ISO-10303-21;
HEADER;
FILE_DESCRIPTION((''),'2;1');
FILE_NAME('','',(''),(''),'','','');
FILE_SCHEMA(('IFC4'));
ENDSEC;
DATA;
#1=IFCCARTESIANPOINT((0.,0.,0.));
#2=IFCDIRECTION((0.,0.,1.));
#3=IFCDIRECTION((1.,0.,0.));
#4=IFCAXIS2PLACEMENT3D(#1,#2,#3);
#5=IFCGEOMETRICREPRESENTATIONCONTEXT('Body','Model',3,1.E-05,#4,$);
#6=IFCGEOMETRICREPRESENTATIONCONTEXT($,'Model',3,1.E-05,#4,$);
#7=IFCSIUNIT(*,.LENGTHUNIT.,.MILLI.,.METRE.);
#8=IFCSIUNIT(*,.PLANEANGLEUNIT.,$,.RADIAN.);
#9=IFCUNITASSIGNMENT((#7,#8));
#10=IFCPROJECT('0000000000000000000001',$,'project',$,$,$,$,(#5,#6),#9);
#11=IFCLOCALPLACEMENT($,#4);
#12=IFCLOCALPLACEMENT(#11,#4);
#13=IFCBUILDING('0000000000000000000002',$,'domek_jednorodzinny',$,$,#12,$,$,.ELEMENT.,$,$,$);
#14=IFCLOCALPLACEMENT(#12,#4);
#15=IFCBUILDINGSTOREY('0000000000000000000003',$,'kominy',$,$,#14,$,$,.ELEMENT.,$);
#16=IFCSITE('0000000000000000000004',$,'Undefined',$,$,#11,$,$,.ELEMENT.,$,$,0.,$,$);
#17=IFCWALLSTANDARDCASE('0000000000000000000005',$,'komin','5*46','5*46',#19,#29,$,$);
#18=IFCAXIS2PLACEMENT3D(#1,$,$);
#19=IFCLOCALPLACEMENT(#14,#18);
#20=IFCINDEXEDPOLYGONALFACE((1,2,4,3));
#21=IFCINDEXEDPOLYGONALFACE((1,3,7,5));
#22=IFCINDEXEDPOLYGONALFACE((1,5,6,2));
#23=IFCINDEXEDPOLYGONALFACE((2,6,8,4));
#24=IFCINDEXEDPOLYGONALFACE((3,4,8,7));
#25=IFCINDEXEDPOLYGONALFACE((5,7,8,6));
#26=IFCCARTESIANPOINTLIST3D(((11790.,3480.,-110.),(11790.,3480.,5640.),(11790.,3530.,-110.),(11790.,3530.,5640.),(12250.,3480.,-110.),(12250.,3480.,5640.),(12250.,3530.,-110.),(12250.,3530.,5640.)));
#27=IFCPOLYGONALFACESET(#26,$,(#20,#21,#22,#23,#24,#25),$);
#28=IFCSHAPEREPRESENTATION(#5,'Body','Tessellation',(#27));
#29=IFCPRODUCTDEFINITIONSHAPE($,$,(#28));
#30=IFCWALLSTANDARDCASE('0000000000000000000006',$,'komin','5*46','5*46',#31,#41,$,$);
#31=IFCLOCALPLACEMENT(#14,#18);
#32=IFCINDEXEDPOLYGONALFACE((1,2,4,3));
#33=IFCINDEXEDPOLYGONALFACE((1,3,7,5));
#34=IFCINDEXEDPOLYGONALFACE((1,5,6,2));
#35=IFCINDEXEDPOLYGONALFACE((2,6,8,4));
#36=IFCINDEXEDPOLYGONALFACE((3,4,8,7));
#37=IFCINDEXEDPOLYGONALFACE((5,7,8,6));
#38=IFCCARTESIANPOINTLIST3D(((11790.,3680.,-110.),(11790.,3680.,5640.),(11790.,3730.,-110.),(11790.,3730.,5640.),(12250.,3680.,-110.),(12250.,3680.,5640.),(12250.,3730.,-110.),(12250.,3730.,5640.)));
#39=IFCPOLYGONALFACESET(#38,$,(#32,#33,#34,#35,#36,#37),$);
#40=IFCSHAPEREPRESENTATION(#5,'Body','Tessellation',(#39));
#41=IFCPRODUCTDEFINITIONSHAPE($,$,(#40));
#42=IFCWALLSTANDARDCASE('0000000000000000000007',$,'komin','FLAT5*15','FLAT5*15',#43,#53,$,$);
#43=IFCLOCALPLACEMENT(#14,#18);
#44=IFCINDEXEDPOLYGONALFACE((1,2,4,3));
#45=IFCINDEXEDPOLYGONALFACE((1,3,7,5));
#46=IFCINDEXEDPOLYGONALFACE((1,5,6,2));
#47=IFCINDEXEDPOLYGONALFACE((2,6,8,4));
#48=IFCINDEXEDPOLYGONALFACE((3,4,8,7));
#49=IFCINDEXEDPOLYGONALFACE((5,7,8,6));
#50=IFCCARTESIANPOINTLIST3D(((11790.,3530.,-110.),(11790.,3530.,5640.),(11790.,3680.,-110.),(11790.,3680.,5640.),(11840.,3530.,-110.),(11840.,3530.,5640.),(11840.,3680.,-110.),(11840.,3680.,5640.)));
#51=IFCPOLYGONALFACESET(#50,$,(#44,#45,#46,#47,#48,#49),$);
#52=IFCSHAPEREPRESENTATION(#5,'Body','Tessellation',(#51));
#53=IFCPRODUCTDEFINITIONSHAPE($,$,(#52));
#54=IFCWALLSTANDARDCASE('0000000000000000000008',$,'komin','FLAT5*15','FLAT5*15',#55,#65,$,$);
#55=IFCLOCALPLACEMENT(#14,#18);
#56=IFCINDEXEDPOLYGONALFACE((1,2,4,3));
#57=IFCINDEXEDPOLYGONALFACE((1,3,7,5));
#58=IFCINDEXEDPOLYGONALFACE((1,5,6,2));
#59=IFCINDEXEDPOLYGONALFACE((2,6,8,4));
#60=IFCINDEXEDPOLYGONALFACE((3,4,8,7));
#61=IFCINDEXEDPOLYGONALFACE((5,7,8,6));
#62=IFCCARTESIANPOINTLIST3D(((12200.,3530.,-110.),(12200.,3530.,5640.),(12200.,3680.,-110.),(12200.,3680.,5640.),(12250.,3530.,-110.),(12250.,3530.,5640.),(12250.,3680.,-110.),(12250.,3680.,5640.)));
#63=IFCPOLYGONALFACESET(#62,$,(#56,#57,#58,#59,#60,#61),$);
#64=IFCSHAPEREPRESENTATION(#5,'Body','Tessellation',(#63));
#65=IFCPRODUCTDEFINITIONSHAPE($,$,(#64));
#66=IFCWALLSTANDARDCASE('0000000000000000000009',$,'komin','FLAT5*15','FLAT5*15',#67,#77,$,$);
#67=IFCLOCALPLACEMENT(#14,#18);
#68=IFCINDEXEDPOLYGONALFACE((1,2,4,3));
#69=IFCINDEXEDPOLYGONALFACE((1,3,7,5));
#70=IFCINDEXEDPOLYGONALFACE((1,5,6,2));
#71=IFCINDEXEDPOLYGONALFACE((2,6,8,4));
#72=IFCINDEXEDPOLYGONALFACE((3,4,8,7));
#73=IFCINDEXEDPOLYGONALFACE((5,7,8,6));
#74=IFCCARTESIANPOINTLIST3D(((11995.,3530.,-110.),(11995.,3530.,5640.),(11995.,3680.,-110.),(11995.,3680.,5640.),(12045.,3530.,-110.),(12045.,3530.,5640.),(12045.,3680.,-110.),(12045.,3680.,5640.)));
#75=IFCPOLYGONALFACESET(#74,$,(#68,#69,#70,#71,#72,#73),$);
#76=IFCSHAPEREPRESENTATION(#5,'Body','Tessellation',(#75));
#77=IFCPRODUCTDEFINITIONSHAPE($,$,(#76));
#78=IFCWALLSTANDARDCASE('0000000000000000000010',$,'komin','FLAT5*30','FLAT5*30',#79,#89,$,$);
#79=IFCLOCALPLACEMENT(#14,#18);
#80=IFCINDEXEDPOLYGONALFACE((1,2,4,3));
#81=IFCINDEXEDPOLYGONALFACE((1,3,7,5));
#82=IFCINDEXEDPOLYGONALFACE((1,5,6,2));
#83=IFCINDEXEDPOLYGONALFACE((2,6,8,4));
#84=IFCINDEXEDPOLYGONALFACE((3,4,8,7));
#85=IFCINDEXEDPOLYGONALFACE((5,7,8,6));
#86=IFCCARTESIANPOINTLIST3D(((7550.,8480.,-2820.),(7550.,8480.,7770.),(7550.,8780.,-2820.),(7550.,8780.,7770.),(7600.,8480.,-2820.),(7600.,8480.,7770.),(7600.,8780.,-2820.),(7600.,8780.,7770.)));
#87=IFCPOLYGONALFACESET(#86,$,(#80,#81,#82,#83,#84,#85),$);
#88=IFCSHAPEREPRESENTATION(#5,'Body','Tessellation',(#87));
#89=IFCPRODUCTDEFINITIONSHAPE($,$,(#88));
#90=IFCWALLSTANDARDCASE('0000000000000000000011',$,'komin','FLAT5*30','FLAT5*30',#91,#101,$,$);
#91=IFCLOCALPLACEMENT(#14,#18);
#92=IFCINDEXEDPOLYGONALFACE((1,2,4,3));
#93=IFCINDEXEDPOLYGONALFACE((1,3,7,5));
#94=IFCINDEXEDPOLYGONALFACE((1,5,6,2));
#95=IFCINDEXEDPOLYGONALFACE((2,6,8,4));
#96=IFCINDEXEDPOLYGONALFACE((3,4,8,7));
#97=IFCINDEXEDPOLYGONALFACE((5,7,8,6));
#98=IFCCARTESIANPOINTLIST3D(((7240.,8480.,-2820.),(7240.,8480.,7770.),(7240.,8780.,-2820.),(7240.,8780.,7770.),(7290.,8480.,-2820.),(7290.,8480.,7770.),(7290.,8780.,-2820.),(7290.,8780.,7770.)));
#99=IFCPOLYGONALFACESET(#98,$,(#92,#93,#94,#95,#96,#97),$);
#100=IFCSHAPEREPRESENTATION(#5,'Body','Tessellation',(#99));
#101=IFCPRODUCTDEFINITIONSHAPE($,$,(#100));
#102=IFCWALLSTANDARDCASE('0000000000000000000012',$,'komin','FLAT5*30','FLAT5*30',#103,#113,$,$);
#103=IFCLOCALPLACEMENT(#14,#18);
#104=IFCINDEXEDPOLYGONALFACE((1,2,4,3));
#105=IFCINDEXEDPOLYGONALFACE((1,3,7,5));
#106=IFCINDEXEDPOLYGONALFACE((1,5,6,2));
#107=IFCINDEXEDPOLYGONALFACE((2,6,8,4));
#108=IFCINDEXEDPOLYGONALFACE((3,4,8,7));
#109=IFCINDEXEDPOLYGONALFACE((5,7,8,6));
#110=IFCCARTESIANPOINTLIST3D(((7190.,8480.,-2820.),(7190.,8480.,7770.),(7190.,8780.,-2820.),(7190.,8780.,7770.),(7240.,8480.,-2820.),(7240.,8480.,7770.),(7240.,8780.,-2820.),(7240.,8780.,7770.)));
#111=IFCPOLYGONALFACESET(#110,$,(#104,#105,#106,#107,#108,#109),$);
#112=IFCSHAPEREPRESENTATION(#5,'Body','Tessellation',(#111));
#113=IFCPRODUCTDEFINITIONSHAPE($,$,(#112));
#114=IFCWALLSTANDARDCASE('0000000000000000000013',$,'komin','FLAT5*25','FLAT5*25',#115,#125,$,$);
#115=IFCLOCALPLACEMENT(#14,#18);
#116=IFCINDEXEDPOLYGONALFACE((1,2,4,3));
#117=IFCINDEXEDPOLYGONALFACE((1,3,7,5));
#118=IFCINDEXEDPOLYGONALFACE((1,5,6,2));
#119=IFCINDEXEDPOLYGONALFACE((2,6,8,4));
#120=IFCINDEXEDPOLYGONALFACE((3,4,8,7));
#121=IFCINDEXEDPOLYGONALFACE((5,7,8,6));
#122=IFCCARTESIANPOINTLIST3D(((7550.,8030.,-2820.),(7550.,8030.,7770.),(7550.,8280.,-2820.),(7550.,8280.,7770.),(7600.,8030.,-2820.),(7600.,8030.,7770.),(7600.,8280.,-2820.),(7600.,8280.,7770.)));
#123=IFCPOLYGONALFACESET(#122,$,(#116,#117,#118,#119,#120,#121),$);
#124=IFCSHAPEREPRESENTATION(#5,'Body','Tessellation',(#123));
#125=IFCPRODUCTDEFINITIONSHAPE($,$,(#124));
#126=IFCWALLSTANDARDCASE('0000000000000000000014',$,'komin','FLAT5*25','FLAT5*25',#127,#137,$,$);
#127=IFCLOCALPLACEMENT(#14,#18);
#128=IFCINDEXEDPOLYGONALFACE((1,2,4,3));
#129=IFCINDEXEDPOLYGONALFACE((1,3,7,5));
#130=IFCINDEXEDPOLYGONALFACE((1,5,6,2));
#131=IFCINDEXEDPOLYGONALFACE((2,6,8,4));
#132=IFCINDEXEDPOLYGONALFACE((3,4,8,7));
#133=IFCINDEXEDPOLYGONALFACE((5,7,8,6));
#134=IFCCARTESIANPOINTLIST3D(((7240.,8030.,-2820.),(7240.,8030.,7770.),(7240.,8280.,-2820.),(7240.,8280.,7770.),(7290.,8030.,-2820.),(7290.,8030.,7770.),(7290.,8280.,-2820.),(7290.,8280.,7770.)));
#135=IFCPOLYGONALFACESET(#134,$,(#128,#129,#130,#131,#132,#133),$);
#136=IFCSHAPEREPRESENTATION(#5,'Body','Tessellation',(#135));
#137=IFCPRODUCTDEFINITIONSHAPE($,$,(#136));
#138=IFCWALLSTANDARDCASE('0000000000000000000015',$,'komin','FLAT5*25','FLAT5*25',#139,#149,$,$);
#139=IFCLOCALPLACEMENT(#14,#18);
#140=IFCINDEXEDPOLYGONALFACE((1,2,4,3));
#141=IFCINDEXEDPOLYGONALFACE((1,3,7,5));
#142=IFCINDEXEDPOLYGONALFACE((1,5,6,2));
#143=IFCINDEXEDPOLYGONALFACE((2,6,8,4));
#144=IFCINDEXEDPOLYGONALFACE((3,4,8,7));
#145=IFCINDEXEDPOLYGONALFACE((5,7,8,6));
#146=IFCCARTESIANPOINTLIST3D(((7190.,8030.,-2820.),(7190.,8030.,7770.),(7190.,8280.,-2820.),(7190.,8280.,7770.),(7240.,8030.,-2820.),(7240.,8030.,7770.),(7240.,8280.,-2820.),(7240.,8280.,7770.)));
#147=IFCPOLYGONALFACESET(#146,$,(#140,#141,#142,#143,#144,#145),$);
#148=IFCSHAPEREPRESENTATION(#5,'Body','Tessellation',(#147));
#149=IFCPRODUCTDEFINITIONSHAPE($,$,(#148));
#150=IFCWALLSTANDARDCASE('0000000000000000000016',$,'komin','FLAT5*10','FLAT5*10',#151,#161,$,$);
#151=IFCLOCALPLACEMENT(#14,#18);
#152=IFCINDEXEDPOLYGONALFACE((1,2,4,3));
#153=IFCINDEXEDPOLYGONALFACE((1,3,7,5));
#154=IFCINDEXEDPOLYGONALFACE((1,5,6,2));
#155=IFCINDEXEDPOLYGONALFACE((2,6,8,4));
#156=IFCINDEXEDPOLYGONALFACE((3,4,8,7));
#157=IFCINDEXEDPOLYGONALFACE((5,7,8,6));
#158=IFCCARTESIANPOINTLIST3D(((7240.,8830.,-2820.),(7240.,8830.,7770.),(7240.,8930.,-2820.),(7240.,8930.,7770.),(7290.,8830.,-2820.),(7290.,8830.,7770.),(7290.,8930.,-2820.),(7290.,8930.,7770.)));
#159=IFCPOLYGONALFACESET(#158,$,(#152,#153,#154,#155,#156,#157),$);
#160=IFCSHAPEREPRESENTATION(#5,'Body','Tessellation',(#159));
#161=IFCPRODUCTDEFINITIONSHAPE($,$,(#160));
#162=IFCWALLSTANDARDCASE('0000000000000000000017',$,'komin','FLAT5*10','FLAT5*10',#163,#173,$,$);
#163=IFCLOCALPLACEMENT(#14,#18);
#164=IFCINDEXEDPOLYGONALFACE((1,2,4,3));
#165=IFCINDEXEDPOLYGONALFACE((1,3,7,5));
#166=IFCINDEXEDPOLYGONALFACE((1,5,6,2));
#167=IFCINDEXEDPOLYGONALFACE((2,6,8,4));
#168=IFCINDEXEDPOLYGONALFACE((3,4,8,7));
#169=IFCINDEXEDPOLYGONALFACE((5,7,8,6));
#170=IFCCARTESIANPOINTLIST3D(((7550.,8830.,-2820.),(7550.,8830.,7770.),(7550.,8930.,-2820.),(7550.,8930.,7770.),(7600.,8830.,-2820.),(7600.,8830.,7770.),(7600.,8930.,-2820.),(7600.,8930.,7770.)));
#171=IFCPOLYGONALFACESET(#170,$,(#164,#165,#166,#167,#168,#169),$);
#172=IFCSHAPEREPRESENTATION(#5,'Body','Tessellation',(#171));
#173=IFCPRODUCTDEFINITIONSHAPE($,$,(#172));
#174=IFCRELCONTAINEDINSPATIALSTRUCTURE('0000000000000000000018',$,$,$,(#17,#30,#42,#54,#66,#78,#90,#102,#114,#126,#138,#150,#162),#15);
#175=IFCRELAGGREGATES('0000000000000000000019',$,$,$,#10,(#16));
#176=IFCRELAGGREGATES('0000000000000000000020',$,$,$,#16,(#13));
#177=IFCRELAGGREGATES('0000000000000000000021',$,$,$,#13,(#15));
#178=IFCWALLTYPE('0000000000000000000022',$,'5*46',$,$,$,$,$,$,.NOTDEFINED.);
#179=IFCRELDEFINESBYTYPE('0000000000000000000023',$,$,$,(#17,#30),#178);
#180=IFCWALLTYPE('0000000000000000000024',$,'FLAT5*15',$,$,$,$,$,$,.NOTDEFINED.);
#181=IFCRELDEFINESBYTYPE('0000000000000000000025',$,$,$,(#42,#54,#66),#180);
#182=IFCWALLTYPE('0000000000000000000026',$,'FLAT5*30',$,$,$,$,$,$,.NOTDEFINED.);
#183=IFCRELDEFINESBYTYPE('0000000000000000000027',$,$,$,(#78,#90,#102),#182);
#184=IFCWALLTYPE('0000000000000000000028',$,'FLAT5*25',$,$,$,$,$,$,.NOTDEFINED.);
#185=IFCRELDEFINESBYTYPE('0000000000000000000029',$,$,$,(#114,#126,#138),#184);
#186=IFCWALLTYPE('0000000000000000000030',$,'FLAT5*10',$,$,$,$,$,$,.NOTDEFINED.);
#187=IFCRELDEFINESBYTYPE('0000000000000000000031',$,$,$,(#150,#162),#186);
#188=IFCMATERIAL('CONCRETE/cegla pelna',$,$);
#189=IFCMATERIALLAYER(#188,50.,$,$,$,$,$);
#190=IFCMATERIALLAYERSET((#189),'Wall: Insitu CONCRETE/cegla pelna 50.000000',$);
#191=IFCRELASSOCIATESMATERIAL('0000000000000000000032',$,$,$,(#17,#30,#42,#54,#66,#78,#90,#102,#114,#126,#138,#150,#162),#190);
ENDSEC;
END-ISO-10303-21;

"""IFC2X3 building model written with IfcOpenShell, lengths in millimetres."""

from ifc_helpers import new_model, si_unit, frame, frame_2d, origin_with_axes, place, context, project, spatial, rectangle, extrude, material, layer, layer_set, layer_usage, type_object, element, save


model = new_model("IFC2X3")

# Units and contexts
model_context_1 = context("Model", 3, precision=1e-05, world=origin_with_axes(), identifier="Body")
model_context_2 = context("Model", 3, precision=1e-05, world=origin_with_axes())
ifc_project = project(units=[si_unit("LENGTHUNIT", "METRE", prefix="MILLI"), si_unit("PLANEANGLEUNIT", "RADIAN")], contexts=[model_context_1, model_context_2])

# Site, building, storey
site_placement = place(None, origin_with_axes())
site = spatial("IfcSite", under=ifc_project, at=site_placement, Name="Undefined", CompositionType="ELEMENT", RefElevation=0.0)
building_placement = place(site_placement, origin_with_axes())
building = spatial("IfcBuilding", under=site, at=building_placement, Name="domek_jednorodzinny", CompositionType="ELEMENT")
storey_placement = place(building_placement, origin_with_axes())
storey = spatial("IfcBuildingStorey", under=building, at=storey_placement, Name="kominy", CompositionType="ELEMENT")

# Walls
ifc_material = material(Name="CONCRETE/cegla pelna")
ifc_layer = layer(ifc_material, 50.0)
ifc_layer_set = layer_set([ifc_layer], Name="Wall: Insitu CONCRETE/cegla pelna 50.000000")
ifc_layer_usage_1 = layer_usage(ifc_layer_set, "AXIS2", "POSITIVE", -25.0)
wall_type_1 = type_object("IfcWallType", Name="5*46", PredefinedType="NOTDEFINED")
wall_1_placement = place(storey_placement, frame((11790.0, 3505.0, -110.0), z_axis=(0.0, 0.0, 1.0), x_axis=(1.0, 0.0, 0.0)))
element("IfcWallStandardCase", 1, at=wall_1_placement, inside=storey, type_object=wall_type_1, material=ifc_layer_usage_1, Name="komin", Description="5*46", ObjectType="5*46", context=model_context_1, shape_type="SweptSolid", body=[
    extrude(rectangle(XDim=460.0, YDim=50.0, at=frame_2d((0.0, 230.0), x_axis=(0.0, -1.0))), frame((0.0, 0.0, 0.0), z_axis=(0.0, 0.0, 1.0), x_axis=(0.0, -1.0, 0.0)), (0.0, 0.0, 1.0), 5750.0),
])
ifc_layer_usage_2 = layer_usage(ifc_layer_set, "AXIS2", "POSITIVE", -25.0)
wall_2_placement = place(storey_placement, frame((11790.0, 3705.0, -110.0), z_axis=(0.0, 0.0, 1.0), x_axis=(1.0, 0.0, 0.0)))
element("IfcWallStandardCase", 2, at=wall_2_placement, inside=storey, type_object=wall_type_1, material=ifc_layer_usage_2, Name="komin", Description="5*46", ObjectType="5*46", context=model_context_1, shape_type="SweptSolid", body=[
    extrude(rectangle(XDim=460.0, YDim=50.0, at=frame_2d((0.0, 230.0), x_axis=(0.0, -1.0))), frame((0.0, 0.0, 0.0), z_axis=(0.0, 0.0, 1.0), x_axis=(0.0, -1.0, 0.0)), (0.0, 0.0, 1.0), 5750.0),
])
ifc_layer_usage_3 = layer_usage(ifc_layer_set, "AXIS2", "POSITIVE", -25.0)
wall_type_2 = type_object("IfcWallType", Name="FLAT5*15", PredefinedType="NOTDEFINED")
wall_3_placement = place(storey_placement, frame((11815.0, 3530.0, -110.0), z_axis=(0.0, 0.0, 1.0), x_axis=(0.0, 1.0, 0.0)))
element("IfcWallStandardCase", 3, at=wall_3_placement, inside=storey, type_object=wall_type_2, material=ifc_layer_usage_3, Name="komin", Description="FLAT5*15", ObjectType="FLAT5*15", context=model_context_1, shape_type="SweptSolid", body=[
    extrude(rectangle(XDim=150.0, YDim=50.0, at=frame_2d((0.0, 75.0), x_axis=(0.0, -1.0))), frame((0.0, 0.0, 0.0), z_axis=(0.0, 0.0, 1.0), x_axis=(0.0, -1.0, 0.0)), (0.0, 0.0, 1.0), 5750.0),
])
ifc_layer_usage_4 = layer_usage(ifc_layer_set, "AXIS2", "POSITIVE", -25.0)
wall_4_placement = place(storey_placement, frame((12225.0, 3530.0, -110.0), z_axis=(0.0, 0.0, 1.0), x_axis=(0.0, 1.0, 0.0)))
element("IfcWallStandardCase", 4, at=wall_4_placement, inside=storey, type_object=wall_type_2, material=ifc_layer_usage_4, Name="komin", Description="FLAT5*15", ObjectType="FLAT5*15", context=model_context_1, shape_type="SweptSolid", body=[
    extrude(rectangle(XDim=150.0, YDim=50.0, at=frame_2d((0.0, 75.0), x_axis=(0.0, -1.0))), frame((0.0, 0.0, 0.0), z_axis=(0.0, 0.0, 1.0), x_axis=(0.0, -1.0, 0.0)), (0.0, 0.0, 1.0), 5750.0),
])
ifc_layer_usage_5 = layer_usage(ifc_layer_set, "AXIS2", "POSITIVE", -25.0)
wall_5_placement = place(storey_placement, frame((12020.0, 3530.0, -110.0), z_axis=(0.0, 0.0, 1.0), x_axis=(0.0, 1.0, 0.0)))
element("IfcWallStandardCase", 5, at=wall_5_placement, inside=storey, type_object=wall_type_2, material=ifc_layer_usage_5, Name="komin", Description="FLAT5*15", ObjectType="FLAT5*15", context=model_context_1, shape_type="SweptSolid", body=[
    extrude(rectangle(XDim=150.0, YDim=50.0, at=frame_2d((0.0, 75.0), x_axis=(0.0, -1.0))), frame((0.0, 0.0, 0.0), z_axis=(0.0, 0.0, 1.0), x_axis=(0.0, -1.0, 0.0)), (0.0, 0.0, 1.0), 5750.0),
])
ifc_layer_usage_6 = layer_usage(ifc_layer_set, "AXIS2", "POSITIVE", -25.0)
wall_type_3 = type_object("IfcWallType", Name="FLAT5*30", PredefinedType="NOTDEFINED")
wall_6_placement = place(storey_placement, frame((7575.0, 8480.0, -2820.0), z_axis=(0.0, 0.0, 1.0), x_axis=(0.0, 1.0, 0.0)))
element("IfcWallStandardCase", 6, at=wall_6_placement, inside=storey, type_object=wall_type_3, material=ifc_layer_usage_6, Name="komin", Description="FLAT5*30", ObjectType="FLAT5*30", context=model_context_1, shape_type="SweptSolid", body=[
    extrude(rectangle(XDim=300.0, YDim=50.0, at=frame_2d((0.0, 150.0), x_axis=(0.0, -1.0))), frame((0.0, 0.0, 0.0), z_axis=(0.0, 0.0, 1.0), x_axis=(0.0, -1.0, 0.0)), (0.0, 0.0, 1.0), 10590.0),
])
ifc_layer_usage_7 = layer_usage(ifc_layer_set, "AXIS2", "POSITIVE", -25.0)
wall_7_placement = place(storey_placement, frame((7265.0, 8480.0, -2820.0), z_axis=(0.0, 0.0, 1.0), x_axis=(0.0, 1.0, 0.0)))
element("IfcWallStandardCase", 7, at=wall_7_placement, inside=storey, type_object=wall_type_3, material=ifc_layer_usage_7, Name="komin", Description="FLAT5*30", ObjectType="FLAT5*30", context=model_context_1, shape_type="SweptSolid", body=[
    extrude(rectangle(XDim=300.0, YDim=50.0, at=frame_2d((0.0, 150.0), x_axis=(0.0, -1.0))), frame((0.0, 0.0, 0.0), z_axis=(0.0, 0.0, 1.0), x_axis=(0.0, -1.0, 0.0)), (0.0, 0.0, 1.0), 10590.0),
])
ifc_layer_usage_8 = layer_usage(ifc_layer_set, "AXIS2", "POSITIVE", -25.0)
wall_8_placement = place(storey_placement, frame((7215.0, 8480.0, -2820.0), z_axis=(0.0, 0.0, 1.0), x_axis=(0.0, 1.0, 0.0)))
element("IfcWallStandardCase", 8, at=wall_8_placement, inside=storey, type_object=wall_type_3, material=ifc_layer_usage_8, Name="komin", Description="FLAT5*30", ObjectType="FLAT5*30", context=model_context_1, shape_type="SweptSolid", body=[
    extrude(rectangle(XDim=300.0, YDim=50.0, at=frame_2d((0.0, 150.0), x_axis=(0.0, -1.0))), frame((0.0, 0.0, 0.0), z_axis=(0.0, 0.0, 1.0), x_axis=(0.0, -1.0, 0.0)), (0.0, 0.0, 1.0), 10590.0),
])
ifc_layer_usage_9 = layer_usage(ifc_layer_set, "AXIS2", "POSITIVE", -25.0)
wall_type_4 = type_object("IfcWallType", Name="FLAT5*25", PredefinedType="NOTDEFINED")
wall_9_placement = place(storey_placement, frame((7575.0, 8030.0, -2820.0), z_axis=(0.0, 0.0, 1.0), x_axis=(0.0, 1.0, 0.0)))
element("IfcWallStandardCase", 9, at=wall_9_placement, inside=storey, type_object=wall_type_4, material=ifc_layer_usage_9, Name="komin", Description="FLAT5*25", ObjectType="FLAT5*25", context=model_context_1, shape_type="SweptSolid", body=[
    extrude(rectangle(XDim=250.0, YDim=50.0, at=frame_2d((0.0, 125.0), x_axis=(0.0, -1.0))), frame((0.0, 0.0, 0.0), z_axis=(0.0, 0.0, 1.0), x_axis=(0.0, -1.0, 0.0)), (0.0, 0.0, 1.0), 10590.0),
])
ifc_layer_usage_10 = layer_usage(ifc_layer_set, "AXIS2", "POSITIVE", -25.0)
wall_10_placement = place(storey_placement, frame((7265.0, 8030.0, -2820.0), z_axis=(0.0, 0.0, 1.0), x_axis=(0.0, 1.0, 0.0)))
element("IfcWallStandardCase", 10, at=wall_10_placement, inside=storey, type_object=wall_type_4, material=ifc_layer_usage_10, Name="komin", Description="FLAT5*25", ObjectType="FLAT5*25", context=model_context_1, shape_type="SweptSolid", body=[
    extrude(rectangle(XDim=250.0, YDim=50.0, at=frame_2d((0.0, 125.0), x_axis=(0.0, -1.0))), frame((0.0, 0.0, 0.0), z_axis=(0.0, 0.0, 1.0), x_axis=(0.0, -1.0, 0.0)), (0.0, 0.0, 1.0), 10590.0),
])
ifc_layer_usage_11 = layer_usage(ifc_layer_set, "AXIS2", "POSITIVE", -25.0)
wall_11_placement = place(storey_placement, frame((7215.0, 8030.0, -2820.0), z_axis=(0.0, 0.0, 1.0), x_axis=(0.0, 1.0, 0.0)))
element("IfcWallStandardCase", 11, at=wall_11_placement, inside=storey, type_object=wall_type_4, material=ifc_layer_usage_11, Name="komin", Description="FLAT5*25", ObjectType="FLAT5*25", context=model_context_1, shape_type="SweptSolid", body=[
    extrude(rectangle(XDim=250.0, YDim=50.0, at=frame_2d((0.0, 125.0), x_axis=(0.0, -1.0))), frame((0.0, 0.0, 0.0), z_axis=(0.0, 0.0, 1.0), x_axis=(0.0, -1.0, 0.0)), (0.0, 0.0, 1.0), 10590.0),
])
ifc_layer_usage_12 = layer_usage(ifc_layer_set, "AXIS2", "POSITIVE", -25.0)
wall_type_5 = type_object("IfcWallType", Name="FLAT5*10", PredefinedType="NOTDEFINED")
wall_12_placement = place(storey_placement, frame((7265.0, 8830.0, -2820.0), z_axis=(0.0, 0.0, 1.0), x_axis=(0.0, 1.0, 0.0)))
element("IfcWallStandardCase", 12, at=wall_12_placement, inside=storey, type_object=wall_type_5, material=ifc_layer_usage_12, Name="komin", Description="FLAT5*10", ObjectType="FLAT5*10", context=model_context_1, shape_type="SweptSolid", body=[
    extrude(rectangle(XDim=100.0, YDim=50.0, at=frame_2d((0.0, 50.0), x_axis=(0.0, -1.0))), frame((0.0, 0.0, 0.0), z_axis=(0.0, 0.0, 1.0), x_axis=(0.0, -1.0, 0.0)), (0.0, 0.0, 1.0), 10590.0),
])
ifc_layer_usage_13 = layer_usage(ifc_layer_set, "AXIS2", "POSITIVE", -25.0)
wall_13_placement = place(storey_placement, frame((7575.0, 8830.0, -2820.0), z_axis=(0.0, 0.0, 1.0), x_axis=(0.0, 1.0, 0.0)))
element("IfcWallStandardCase", 13, at=wall_13_placement, inside=storey, type_object=wall_type_5, material=ifc_layer_usage_13, Name="komin", Description="FLAT5*10", ObjectType="FLAT5*10", context=model_context_1, shape_type="SweptSolid", body=[
    extrude(rectangle(XDim=100.0, YDim=50.0, at=frame_2d((0.0, 50.0), x_axis=(0.0, -1.0))), frame((0.0, 0.0, 0.0), z_axis=(0.0, 0.0, 1.0), x_axis=(0.0, -1.0, 0.0)), (0.0, 0.0, 1.0), 10590.0),
])

save(model, "model.ifc")
